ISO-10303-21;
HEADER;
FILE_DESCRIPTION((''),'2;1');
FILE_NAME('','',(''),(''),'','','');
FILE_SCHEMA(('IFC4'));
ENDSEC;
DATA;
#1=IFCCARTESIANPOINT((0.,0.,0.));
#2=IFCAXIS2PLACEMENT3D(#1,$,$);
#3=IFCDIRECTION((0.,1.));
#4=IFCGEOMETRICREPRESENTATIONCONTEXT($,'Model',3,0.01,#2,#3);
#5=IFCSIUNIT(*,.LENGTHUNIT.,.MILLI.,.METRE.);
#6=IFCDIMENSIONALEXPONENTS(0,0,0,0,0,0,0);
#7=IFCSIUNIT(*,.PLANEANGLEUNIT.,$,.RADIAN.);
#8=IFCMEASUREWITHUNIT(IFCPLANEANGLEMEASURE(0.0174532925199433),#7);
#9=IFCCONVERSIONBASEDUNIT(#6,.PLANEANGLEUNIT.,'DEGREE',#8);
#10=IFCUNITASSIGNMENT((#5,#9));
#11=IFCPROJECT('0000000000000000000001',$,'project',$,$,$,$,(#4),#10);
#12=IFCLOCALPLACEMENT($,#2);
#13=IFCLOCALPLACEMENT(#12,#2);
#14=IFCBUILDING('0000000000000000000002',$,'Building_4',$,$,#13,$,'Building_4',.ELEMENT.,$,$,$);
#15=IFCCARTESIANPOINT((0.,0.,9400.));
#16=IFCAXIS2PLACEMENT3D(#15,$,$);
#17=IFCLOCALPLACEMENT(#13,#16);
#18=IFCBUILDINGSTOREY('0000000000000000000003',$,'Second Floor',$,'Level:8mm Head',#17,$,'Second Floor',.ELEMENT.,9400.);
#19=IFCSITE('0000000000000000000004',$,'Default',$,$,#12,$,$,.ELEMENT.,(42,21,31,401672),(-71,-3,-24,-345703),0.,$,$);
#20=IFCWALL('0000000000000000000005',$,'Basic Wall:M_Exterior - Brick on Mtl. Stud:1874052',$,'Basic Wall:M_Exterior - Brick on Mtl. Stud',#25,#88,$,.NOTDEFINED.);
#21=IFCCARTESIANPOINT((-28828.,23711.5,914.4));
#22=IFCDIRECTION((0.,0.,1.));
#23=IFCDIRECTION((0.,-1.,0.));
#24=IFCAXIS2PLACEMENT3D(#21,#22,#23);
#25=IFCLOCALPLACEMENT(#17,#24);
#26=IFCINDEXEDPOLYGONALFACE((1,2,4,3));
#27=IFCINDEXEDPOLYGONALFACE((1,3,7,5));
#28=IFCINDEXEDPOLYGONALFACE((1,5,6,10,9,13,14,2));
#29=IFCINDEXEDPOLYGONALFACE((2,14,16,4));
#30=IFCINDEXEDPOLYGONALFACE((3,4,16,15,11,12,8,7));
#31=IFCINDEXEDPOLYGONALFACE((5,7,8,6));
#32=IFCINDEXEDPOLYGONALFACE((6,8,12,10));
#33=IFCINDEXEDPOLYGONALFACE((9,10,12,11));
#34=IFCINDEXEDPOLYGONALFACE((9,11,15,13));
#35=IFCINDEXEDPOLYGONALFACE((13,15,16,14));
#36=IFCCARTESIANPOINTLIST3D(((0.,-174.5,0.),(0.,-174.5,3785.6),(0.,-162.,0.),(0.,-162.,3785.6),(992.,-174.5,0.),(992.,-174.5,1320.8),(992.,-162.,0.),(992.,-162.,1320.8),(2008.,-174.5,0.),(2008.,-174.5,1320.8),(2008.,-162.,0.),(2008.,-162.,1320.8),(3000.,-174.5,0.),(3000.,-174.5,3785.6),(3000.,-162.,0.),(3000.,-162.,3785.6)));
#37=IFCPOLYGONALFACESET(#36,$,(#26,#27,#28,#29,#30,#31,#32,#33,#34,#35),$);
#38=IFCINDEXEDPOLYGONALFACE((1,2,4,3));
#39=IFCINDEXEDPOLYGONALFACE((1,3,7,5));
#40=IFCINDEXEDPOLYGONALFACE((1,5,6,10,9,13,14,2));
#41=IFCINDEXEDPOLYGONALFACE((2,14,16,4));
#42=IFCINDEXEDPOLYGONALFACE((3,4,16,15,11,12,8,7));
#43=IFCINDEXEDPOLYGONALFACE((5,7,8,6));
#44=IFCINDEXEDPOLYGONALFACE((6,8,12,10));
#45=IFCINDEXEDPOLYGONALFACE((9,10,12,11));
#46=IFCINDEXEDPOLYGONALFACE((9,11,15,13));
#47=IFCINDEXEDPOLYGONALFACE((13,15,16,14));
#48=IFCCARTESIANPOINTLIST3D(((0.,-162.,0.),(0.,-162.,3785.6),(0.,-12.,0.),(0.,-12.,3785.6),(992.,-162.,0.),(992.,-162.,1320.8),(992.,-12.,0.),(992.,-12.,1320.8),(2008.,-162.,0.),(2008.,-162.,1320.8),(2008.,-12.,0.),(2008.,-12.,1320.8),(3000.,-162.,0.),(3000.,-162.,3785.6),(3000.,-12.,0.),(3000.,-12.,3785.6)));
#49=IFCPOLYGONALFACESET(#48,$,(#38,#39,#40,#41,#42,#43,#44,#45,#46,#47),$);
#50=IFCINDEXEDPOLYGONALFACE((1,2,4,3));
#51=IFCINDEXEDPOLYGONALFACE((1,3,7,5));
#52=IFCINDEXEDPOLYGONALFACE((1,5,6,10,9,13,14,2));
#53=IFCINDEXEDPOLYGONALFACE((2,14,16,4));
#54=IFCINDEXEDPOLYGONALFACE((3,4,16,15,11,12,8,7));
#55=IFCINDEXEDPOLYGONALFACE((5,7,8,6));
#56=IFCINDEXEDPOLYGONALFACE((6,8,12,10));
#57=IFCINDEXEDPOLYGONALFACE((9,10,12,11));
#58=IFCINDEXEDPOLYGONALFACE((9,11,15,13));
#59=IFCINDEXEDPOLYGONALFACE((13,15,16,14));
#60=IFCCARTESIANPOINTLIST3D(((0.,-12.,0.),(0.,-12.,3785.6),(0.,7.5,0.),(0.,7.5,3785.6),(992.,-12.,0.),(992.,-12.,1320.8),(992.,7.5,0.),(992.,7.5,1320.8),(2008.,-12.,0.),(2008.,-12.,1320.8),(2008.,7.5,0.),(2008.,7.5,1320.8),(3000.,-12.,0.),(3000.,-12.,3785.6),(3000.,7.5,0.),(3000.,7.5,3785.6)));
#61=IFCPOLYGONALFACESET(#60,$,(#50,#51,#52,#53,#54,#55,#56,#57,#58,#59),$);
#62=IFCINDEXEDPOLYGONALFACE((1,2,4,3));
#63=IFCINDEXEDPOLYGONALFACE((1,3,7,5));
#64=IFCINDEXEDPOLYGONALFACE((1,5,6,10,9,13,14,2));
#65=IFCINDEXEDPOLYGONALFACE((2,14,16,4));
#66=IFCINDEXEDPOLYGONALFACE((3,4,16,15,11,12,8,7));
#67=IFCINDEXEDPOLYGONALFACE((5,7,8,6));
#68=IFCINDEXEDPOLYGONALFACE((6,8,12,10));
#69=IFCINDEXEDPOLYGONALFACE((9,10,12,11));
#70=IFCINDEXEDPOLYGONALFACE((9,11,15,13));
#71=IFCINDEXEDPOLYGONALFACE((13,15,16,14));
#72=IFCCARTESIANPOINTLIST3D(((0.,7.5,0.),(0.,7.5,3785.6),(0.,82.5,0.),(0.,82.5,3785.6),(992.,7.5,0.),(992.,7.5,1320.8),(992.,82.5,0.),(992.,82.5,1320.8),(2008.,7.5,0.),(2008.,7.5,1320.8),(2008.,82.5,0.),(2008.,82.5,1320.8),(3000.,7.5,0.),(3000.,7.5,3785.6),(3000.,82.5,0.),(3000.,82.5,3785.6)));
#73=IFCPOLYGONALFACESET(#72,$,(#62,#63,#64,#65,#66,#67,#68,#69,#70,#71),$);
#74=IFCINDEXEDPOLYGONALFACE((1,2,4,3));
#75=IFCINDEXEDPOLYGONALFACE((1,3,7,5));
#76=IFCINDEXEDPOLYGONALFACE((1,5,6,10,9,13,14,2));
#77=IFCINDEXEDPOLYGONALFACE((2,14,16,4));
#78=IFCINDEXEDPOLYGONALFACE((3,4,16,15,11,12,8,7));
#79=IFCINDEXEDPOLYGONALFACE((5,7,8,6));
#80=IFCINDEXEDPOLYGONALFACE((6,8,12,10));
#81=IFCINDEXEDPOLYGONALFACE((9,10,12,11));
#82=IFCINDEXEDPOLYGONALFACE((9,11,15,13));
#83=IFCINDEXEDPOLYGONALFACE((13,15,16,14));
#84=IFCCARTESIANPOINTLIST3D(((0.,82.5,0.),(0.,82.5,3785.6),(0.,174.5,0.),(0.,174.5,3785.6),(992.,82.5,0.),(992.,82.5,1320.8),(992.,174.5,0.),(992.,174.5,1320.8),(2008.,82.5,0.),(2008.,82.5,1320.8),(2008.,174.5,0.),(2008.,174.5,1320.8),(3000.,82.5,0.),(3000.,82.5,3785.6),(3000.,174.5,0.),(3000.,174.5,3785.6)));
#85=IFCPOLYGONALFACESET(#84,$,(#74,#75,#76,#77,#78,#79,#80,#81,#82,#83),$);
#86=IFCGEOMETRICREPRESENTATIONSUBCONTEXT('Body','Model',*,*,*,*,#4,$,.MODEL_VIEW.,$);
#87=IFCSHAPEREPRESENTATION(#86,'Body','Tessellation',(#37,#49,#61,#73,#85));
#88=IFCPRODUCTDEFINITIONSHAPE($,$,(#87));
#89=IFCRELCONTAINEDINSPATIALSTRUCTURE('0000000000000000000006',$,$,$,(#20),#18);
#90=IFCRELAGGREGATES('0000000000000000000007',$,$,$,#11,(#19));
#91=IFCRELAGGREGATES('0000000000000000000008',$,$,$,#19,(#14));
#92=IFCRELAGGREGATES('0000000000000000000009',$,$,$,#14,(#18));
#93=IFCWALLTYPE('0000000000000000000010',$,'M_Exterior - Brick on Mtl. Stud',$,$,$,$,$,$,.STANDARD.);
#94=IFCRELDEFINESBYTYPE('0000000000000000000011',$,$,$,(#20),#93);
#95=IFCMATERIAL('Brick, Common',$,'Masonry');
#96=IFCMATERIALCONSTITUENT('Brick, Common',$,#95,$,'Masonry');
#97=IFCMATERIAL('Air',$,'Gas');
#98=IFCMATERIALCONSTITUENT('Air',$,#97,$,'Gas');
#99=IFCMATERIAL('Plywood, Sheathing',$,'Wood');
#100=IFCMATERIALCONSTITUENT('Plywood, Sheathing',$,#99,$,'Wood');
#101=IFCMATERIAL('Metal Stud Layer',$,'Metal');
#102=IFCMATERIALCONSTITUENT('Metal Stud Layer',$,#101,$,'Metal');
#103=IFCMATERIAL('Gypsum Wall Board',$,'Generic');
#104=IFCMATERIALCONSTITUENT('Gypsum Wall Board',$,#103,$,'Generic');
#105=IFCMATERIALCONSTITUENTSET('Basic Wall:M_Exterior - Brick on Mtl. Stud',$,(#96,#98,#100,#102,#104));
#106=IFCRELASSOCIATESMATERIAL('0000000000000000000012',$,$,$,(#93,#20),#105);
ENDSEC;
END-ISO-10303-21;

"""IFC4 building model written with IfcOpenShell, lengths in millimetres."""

from ifc_helpers import new_model, entity, si_unit, converted_unit, direction, frame, origin, place, context, subcontext, project, spatial, indexed_curve, outline, extrude, material, constituent, constituent_set, type_object, element, save


model = new_model("IFC4")

# Units and contexts
model_context = context("Model", 3, precision=0.01, world=origin(), true_north=direction((0.0, 1.0)))
body_context = subcontext(model_context, "Body", "Model", "MODEL_VIEW")
ifc_project = project(units=[si_unit("LENGTHUNIT", "METRE", prefix="MILLI"), converted_unit("PLANEANGLEUNIT", "DEGREE", entity("IfcPlaneAngleMeasure", 0.0174532925199433), si_unit("PLANEANGLEUNIT", "RADIAN"), dimensions=[0, 0, 0, 0, 0, 0, 0])], contexts=[model_context])

# Site, building, storey
site_placement = place(None, origin())
site = spatial("IfcSite", under=ifc_project, at=site_placement, Name="Default", CompositionType="ELEMENT", RefLatitude=(42, 21, 31, 401672), RefLongitude=(-71, -3, -24, -345703), RefElevation=0.0)
building_placement = place(site_placement, origin())
building = spatial("IfcBuilding", under=site, at=building_placement, Name="Building_4", LongName="Building_4", CompositionType="ELEMENT")
storey_placement = place(building_placement, frame((0.0, 0.0, 9400.0)))
storey = spatial("IfcBuildingStorey", under=building, at=storey_placement, Name="Second Floor", ObjectType="Level:8mm Head", LongName="Second Floor", CompositionType="ELEMENT", Elevation=9400.0)

# Shared definitions
ifc_material_1 = material(Name="Brick, Common", Category="Masonry")
ifc_constituent_1 = constituent(ifc_material_1, Name="Brick, Common", Category="Masonry")
ifc_material_2 = material(Name="Air", Category="Gas")
ifc_constituent_2 = constituent(ifc_material_2, Name="Air", Category="Gas")
ifc_material_3 = material(Name="Plywood, Sheathing", Category="Wood")
ifc_constituent_3 = constituent(ifc_material_3, Name="Plywood, Sheathing", Category="Wood")
ifc_material_4 = material(Name="Metal Stud Layer", Category="Metal")
ifc_constituent_4 = constituent(ifc_material_4, Name="Metal Stud Layer", Category="Metal")
ifc_material_5 = material(Name="Gypsum Wall Board", Category="Generic")
ifc_constituent_5 = constituent(ifc_material_5, Name="Gypsum Wall Board", Category="Generic")
ifc_constituent_set_1 = constituent_set(constituents=[ifc_constituent_1, ifc_constituent_2, ifc_constituent_3, ifc_constituent_4, ifc_constituent_5], Name="Basic Wall:M_Exterior - Brick on Mtl. Stud")
wall_type_1 = type_object("IfcWallType", Name="M_Exterior - Brick on Mtl. Stud", PredefinedType="STANDARD", material=ifc_constituent_set_1)

# Wall, opening
wall_1_placement = place(storey_placement, frame((-28828.0, 23711.5, 914.4), z_axis=(0.0, 0.0, 1.0), x_axis=(0.0, -1.0, 0.0)))
wall_1 = element("IfcWall", 1, at=wall_1_placement, inside=storey, type_object=wall_type_1, material=ifc_constituent_set_1, Name="Basic Wall:M_Exterior - Brick on Mtl. Stud:1874052", ObjectType="Basic Wall:M_Exterior - Brick on Mtl. Stud", PredefinedType="NOTDEFINED", context=body_context, shape_type="SweptSolid", body=[
    extrude(outline(indexed_curve([(-1500.0, -1276.6), (-508.0, -1276.6), (-508.0, 44.2), (508.0, 44.2), (508.0, -1276.6), (1500.0, -1276.6), (1500.0, 2509.0), (-1500.0, 2509.0), (-1500.0, -1276.6)], self_intersect=False)), frame((1500.0, -174.5, 1276.6), z_axis=(0.0, 1.0, 0.0), x_axis=(-1.0, 0.0, 0.0)), (0.0, 0.0, 1.0), 12.5),
    extrude(outline(indexed_curve([(-1276.6, -508.0), (-1276.6, -1500.0), (2509.0, -1500.0), (2509.0, 1500.0), (-1276.6, 1500.0), (-1276.6, 508.0), (44.2, 508.0), (44.2, -508.0), (-1276.6, -508.0)], self_intersect=False)), frame((1500.0, -162.0, 1276.6), z_axis=(0.0, -1.0, 0.0), x_axis=(0.0, 0.0, 1.0)), (0.0, 0.0, -1.0), 150.0),
    extrude(outline(indexed_curve([(-1276.6, -508.0), (-1276.6, -1500.0), (2509.0, -1500.0), (2509.0, 1500.0), (-1276.6, 1500.0), (-1276.6, 508.0), (44.2, 508.0), (44.2, -508.0), (-1276.6, -508.0)], self_intersect=False)), frame((1500.0, -12.0, 1276.6), z_axis=(0.0, -1.0, 0.0), x_axis=(0.0, 0.0, 1.0)), (0.0, 0.0, -1.0), 19.5),
    extrude(outline(indexed_curve([(-1276.6, -508.0), (-1276.6, -1500.0), (2509.0, -1500.0), (2509.0, 1500.0), (-1276.6, 1500.0), (-1276.6, 508.0), (44.2, 508.0), (44.2, -508.0), (-1276.6, -508.0)], self_intersect=False)), frame((1500.0, 7.5, 1276.6), z_axis=(0.0, -1.0, 0.0), x_axis=(0.0, 0.0, 1.0)), (0.0, 0.0, -1.0), 75.0),
    extrude(outline(indexed_curve([(-1276.6, -508.0), (-1276.6, -1500.0), (2509.0, -1500.0), (2509.0, 1500.0), (-1276.6, 1500.0), (-1276.6, 508.0), (44.2, 508.0), (44.2, -508.0), (-1276.6, -508.0)], self_intersect=False)), frame((1500.0, 82.5, 1276.6), z_axis=(0.0, -1.0, 0.0), x_axis=(0.0, 0.0, 1.0)), (0.0, 0.0, -1.0), 92.0),
])
opening_1_placement = place(wall_1_placement, frame((992.0, -174.5, -914.4)))
element("IfcOpeningElement", 2, at=opening_1_placement, cuts=wall_1, PredefinedType="OPENING", context=body_context, shape_type="SweptSolid", body=[
    extrude(outline(indexed_curve([(0.0, 1016.0), (0.0, 0.0), (2235.2, 0.0), (2235.2, 1016.0), (0.0, 1016.0)], self_intersect=False)), frame((0.0, 0.0, 0.0), z_axis=(0.0, 1.0, 0.0), x_axis=(0.0, 0.0, 1.0)), (0.0, 0.0, 1.0), 349.0),
])

save(model, "model.ifc")
